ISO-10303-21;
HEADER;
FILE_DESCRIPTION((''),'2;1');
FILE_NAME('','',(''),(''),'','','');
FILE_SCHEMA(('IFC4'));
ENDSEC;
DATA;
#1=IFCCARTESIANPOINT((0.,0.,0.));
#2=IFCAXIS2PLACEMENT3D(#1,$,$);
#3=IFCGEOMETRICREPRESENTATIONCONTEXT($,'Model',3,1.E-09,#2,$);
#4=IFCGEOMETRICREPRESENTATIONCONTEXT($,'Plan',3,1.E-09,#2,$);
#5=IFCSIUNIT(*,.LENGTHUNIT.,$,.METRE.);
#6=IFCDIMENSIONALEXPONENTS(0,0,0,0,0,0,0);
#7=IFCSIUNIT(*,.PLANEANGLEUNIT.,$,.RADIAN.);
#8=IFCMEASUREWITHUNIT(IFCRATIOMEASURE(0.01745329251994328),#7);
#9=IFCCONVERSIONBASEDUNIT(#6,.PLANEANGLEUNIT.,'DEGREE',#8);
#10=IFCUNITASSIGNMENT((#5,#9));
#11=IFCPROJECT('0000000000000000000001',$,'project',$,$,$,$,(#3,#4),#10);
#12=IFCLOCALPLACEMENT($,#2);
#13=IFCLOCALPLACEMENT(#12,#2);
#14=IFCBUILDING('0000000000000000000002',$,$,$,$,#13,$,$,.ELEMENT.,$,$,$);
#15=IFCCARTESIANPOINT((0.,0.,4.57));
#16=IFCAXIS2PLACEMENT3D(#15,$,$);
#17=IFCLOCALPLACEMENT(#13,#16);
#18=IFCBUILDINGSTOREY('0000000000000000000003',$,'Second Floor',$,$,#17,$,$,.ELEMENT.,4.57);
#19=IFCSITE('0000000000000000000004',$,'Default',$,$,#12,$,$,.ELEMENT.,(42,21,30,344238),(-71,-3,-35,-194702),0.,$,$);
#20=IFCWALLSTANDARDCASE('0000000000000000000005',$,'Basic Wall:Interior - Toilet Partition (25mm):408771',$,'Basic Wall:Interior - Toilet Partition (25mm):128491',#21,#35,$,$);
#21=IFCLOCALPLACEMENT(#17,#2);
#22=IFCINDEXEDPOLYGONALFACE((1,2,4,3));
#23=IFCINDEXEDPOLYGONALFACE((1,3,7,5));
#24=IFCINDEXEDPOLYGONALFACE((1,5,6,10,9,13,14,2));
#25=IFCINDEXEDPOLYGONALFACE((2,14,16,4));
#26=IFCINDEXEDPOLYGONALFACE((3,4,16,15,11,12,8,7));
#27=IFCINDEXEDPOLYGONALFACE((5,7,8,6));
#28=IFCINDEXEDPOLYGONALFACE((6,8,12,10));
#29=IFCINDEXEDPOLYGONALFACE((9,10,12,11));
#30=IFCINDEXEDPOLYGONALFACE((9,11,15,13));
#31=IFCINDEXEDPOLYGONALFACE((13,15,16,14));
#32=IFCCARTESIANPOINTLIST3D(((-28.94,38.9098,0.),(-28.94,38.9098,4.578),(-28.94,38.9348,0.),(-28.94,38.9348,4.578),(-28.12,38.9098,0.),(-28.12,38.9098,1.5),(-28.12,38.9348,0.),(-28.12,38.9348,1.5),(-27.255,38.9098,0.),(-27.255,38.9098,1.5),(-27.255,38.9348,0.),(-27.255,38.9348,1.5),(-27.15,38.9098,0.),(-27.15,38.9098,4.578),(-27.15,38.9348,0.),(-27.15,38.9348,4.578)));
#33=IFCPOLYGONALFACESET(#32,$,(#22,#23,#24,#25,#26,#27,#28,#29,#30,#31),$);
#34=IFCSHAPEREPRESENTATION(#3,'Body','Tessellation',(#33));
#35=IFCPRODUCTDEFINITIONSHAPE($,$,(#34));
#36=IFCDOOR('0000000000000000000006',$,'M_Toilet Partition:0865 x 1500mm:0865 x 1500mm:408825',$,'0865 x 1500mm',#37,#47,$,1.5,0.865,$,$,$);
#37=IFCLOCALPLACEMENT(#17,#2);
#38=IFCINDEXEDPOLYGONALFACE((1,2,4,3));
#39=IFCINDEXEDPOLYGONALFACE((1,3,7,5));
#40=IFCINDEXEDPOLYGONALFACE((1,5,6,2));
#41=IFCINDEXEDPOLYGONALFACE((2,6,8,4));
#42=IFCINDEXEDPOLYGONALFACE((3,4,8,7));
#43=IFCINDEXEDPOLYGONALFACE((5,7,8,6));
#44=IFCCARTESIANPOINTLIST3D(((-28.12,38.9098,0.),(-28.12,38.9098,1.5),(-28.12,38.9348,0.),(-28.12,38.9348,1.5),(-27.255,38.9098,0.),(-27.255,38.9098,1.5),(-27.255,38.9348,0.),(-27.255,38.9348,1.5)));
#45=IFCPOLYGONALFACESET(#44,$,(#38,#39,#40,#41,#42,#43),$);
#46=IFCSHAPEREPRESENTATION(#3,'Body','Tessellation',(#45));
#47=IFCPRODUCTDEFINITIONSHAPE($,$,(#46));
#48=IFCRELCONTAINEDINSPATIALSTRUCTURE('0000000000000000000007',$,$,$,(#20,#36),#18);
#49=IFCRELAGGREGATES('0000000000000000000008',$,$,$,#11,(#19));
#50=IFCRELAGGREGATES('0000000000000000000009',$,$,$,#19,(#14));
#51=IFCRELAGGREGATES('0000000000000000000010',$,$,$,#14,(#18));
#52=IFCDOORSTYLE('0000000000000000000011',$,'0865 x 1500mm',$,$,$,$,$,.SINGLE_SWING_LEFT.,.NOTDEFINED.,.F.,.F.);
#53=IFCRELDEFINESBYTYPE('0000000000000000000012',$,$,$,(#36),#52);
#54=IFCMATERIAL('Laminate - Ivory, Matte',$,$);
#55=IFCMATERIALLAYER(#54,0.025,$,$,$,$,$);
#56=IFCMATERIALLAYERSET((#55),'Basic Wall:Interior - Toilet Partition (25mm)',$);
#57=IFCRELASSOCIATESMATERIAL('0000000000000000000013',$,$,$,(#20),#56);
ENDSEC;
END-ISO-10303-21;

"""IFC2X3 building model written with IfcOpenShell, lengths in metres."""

from ifc_helpers import new_model, entity, si_unit, converted_unit, frame, frame_2d, origin, origin_2d_with_axis, place, context, project, spatial, rectangle, extrude, source, transform, mapped, material, layer, layer_set, layer_usage, type_object, type_shapes, element, fill, save


model = new_model("IFC2X3")

# Units and contexts
model_context = context("Model", 3, precision=1e-09, world=origin())
plan_context = context("Plan", 3, precision=1e-09, world=origin())
ifc_project = project(units=[si_unit("LENGTHUNIT", "METRE"), converted_unit("PLANEANGLEUNIT", "DEGREE", entity("IfcRatioMeasure", 0.01745329251994328), si_unit("PLANEANGLEUNIT", "RADIAN"), dimensions=[0, 0, 0, 0, 0, 0, 0])], contexts=[model_context, plan_context])

# Site, building, storey
site_placement = place(None, origin())
site = spatial("IfcSite", under=ifc_project, at=site_placement, Name="Default", CompositionType="ELEMENT", RefLatitude=(42, 21, 30, 344238), RefLongitude=(-71, -3, -35, -194702), RefElevation=0.0)
building_placement = place(site_placement, origin())
building = spatial("IfcBuilding", under=site, at=building_placement, CompositionType="ELEMENT")
storey_placement = place(building_placement, frame((0.0, 0.0, 4.57)))
storey = spatial("IfcBuildingStorey", under=building, at=storey_placement, Name="Second Floor", CompositionType="ELEMENT", Elevation=4.57)

# Shared definitions
ifc_material_1 = material(Name="Laminate - Ivory, Matte")
ifc_layer_1 = layer(ifc_material_1, 0.025)
ifc_layer_set_1 = layer_set([ifc_layer_1], Name="Basic Wall:Interior - Toilet Partition (25mm)")
ifc_layer_usage_1 = layer_usage(ifc_layer_set_1, "AXIS2", "NEGATIVE", 0.0125)
door_style_1 = type_object("IfcDoorStyle", Name="0865 x 1500mm", ConstructionType="NOTDEFINED", OperationType="SINGLE_SWING_LEFT", ParameterTakesPrecedence=False, Sizeable=False)
shared_shape_1 = source(origin(), model_context, "Body", "SweptSolid", [
    extrude(rectangle(XDim=0.865, YDim=0.025, at=origin_2d_with_axis()), frame((0.4325, 0.0125, 0.0)), (0.0, 0.0, 1.0), 1.5),
])
type_shapes(door_style_1, [shared_shape_1])

# Wall, opening, door
wall_1_placement = place(storey_placement, frame((-28.94, 38.9223, 0.0)))
wall_1 = element("IfcWallStandardCase", 1, at=wall_1_placement, inside=storey, material=ifc_layer_usage_1, Name="Basic Wall:Interior - Toilet Partition (25mm):408771", ObjectType="Basic Wall:Interior - Toilet Partition (25mm):128491", context=model_context, shape_type="SweptSolid", body=[
    extrude(rectangle(XDim=1.79, YDim=0.025, at=frame_2d((0.895, 0.0), x_axis=(-1.0, 0.0))), origin(), (0.0, 0.0, 1.0), 4.578),
])
opening_1_placement = place(wall_1_placement, frame((1.685, 0.0125, 0.0)))
opening_1 = element("IfcOpeningElement", 2, at=opening_1_placement, cuts=wall_1, ObjectType="Opening", context=model_context, shape_type="SweptSolid", body=[
    extrude(rectangle(XDim=0.865, YDim=1.5, at=frame_2d((0.75, 0.4325), x_axis=(0.0, -1.0))), frame((0.0, 0.0, 0.0), z_axis=(0.0, -1.0, 0.0), x_axis=(0.0, 0.0, 1.0)), (0.0, 0.0, 1.0), 0.025),
])
door_1_placement = place(opening_1_placement, frame((0.0, 0.0, 0.0), z_axis=(0.0, 0.0, 1.0), x_axis=(-1.0, 0.0, 0.0)))
door_1 = element("IfcDoor", 3, at=door_1_placement, inside=storey, type_object=door_style_1, Name="M_Toilet Partition:0865 x 1500mm:0865 x 1500mm:408825", ObjectType="0865 x 1500mm", OverallHeight=1.5, OverallWidth=0.865, context=model_context, shape_type="MappedRepresentation", body=[
    mapped(shared_shape_1, transform((0.0, 0.0, 0.0), scale=1.0)),
])
fill(opening_1, door_1)

save(model, "model.ifc")
